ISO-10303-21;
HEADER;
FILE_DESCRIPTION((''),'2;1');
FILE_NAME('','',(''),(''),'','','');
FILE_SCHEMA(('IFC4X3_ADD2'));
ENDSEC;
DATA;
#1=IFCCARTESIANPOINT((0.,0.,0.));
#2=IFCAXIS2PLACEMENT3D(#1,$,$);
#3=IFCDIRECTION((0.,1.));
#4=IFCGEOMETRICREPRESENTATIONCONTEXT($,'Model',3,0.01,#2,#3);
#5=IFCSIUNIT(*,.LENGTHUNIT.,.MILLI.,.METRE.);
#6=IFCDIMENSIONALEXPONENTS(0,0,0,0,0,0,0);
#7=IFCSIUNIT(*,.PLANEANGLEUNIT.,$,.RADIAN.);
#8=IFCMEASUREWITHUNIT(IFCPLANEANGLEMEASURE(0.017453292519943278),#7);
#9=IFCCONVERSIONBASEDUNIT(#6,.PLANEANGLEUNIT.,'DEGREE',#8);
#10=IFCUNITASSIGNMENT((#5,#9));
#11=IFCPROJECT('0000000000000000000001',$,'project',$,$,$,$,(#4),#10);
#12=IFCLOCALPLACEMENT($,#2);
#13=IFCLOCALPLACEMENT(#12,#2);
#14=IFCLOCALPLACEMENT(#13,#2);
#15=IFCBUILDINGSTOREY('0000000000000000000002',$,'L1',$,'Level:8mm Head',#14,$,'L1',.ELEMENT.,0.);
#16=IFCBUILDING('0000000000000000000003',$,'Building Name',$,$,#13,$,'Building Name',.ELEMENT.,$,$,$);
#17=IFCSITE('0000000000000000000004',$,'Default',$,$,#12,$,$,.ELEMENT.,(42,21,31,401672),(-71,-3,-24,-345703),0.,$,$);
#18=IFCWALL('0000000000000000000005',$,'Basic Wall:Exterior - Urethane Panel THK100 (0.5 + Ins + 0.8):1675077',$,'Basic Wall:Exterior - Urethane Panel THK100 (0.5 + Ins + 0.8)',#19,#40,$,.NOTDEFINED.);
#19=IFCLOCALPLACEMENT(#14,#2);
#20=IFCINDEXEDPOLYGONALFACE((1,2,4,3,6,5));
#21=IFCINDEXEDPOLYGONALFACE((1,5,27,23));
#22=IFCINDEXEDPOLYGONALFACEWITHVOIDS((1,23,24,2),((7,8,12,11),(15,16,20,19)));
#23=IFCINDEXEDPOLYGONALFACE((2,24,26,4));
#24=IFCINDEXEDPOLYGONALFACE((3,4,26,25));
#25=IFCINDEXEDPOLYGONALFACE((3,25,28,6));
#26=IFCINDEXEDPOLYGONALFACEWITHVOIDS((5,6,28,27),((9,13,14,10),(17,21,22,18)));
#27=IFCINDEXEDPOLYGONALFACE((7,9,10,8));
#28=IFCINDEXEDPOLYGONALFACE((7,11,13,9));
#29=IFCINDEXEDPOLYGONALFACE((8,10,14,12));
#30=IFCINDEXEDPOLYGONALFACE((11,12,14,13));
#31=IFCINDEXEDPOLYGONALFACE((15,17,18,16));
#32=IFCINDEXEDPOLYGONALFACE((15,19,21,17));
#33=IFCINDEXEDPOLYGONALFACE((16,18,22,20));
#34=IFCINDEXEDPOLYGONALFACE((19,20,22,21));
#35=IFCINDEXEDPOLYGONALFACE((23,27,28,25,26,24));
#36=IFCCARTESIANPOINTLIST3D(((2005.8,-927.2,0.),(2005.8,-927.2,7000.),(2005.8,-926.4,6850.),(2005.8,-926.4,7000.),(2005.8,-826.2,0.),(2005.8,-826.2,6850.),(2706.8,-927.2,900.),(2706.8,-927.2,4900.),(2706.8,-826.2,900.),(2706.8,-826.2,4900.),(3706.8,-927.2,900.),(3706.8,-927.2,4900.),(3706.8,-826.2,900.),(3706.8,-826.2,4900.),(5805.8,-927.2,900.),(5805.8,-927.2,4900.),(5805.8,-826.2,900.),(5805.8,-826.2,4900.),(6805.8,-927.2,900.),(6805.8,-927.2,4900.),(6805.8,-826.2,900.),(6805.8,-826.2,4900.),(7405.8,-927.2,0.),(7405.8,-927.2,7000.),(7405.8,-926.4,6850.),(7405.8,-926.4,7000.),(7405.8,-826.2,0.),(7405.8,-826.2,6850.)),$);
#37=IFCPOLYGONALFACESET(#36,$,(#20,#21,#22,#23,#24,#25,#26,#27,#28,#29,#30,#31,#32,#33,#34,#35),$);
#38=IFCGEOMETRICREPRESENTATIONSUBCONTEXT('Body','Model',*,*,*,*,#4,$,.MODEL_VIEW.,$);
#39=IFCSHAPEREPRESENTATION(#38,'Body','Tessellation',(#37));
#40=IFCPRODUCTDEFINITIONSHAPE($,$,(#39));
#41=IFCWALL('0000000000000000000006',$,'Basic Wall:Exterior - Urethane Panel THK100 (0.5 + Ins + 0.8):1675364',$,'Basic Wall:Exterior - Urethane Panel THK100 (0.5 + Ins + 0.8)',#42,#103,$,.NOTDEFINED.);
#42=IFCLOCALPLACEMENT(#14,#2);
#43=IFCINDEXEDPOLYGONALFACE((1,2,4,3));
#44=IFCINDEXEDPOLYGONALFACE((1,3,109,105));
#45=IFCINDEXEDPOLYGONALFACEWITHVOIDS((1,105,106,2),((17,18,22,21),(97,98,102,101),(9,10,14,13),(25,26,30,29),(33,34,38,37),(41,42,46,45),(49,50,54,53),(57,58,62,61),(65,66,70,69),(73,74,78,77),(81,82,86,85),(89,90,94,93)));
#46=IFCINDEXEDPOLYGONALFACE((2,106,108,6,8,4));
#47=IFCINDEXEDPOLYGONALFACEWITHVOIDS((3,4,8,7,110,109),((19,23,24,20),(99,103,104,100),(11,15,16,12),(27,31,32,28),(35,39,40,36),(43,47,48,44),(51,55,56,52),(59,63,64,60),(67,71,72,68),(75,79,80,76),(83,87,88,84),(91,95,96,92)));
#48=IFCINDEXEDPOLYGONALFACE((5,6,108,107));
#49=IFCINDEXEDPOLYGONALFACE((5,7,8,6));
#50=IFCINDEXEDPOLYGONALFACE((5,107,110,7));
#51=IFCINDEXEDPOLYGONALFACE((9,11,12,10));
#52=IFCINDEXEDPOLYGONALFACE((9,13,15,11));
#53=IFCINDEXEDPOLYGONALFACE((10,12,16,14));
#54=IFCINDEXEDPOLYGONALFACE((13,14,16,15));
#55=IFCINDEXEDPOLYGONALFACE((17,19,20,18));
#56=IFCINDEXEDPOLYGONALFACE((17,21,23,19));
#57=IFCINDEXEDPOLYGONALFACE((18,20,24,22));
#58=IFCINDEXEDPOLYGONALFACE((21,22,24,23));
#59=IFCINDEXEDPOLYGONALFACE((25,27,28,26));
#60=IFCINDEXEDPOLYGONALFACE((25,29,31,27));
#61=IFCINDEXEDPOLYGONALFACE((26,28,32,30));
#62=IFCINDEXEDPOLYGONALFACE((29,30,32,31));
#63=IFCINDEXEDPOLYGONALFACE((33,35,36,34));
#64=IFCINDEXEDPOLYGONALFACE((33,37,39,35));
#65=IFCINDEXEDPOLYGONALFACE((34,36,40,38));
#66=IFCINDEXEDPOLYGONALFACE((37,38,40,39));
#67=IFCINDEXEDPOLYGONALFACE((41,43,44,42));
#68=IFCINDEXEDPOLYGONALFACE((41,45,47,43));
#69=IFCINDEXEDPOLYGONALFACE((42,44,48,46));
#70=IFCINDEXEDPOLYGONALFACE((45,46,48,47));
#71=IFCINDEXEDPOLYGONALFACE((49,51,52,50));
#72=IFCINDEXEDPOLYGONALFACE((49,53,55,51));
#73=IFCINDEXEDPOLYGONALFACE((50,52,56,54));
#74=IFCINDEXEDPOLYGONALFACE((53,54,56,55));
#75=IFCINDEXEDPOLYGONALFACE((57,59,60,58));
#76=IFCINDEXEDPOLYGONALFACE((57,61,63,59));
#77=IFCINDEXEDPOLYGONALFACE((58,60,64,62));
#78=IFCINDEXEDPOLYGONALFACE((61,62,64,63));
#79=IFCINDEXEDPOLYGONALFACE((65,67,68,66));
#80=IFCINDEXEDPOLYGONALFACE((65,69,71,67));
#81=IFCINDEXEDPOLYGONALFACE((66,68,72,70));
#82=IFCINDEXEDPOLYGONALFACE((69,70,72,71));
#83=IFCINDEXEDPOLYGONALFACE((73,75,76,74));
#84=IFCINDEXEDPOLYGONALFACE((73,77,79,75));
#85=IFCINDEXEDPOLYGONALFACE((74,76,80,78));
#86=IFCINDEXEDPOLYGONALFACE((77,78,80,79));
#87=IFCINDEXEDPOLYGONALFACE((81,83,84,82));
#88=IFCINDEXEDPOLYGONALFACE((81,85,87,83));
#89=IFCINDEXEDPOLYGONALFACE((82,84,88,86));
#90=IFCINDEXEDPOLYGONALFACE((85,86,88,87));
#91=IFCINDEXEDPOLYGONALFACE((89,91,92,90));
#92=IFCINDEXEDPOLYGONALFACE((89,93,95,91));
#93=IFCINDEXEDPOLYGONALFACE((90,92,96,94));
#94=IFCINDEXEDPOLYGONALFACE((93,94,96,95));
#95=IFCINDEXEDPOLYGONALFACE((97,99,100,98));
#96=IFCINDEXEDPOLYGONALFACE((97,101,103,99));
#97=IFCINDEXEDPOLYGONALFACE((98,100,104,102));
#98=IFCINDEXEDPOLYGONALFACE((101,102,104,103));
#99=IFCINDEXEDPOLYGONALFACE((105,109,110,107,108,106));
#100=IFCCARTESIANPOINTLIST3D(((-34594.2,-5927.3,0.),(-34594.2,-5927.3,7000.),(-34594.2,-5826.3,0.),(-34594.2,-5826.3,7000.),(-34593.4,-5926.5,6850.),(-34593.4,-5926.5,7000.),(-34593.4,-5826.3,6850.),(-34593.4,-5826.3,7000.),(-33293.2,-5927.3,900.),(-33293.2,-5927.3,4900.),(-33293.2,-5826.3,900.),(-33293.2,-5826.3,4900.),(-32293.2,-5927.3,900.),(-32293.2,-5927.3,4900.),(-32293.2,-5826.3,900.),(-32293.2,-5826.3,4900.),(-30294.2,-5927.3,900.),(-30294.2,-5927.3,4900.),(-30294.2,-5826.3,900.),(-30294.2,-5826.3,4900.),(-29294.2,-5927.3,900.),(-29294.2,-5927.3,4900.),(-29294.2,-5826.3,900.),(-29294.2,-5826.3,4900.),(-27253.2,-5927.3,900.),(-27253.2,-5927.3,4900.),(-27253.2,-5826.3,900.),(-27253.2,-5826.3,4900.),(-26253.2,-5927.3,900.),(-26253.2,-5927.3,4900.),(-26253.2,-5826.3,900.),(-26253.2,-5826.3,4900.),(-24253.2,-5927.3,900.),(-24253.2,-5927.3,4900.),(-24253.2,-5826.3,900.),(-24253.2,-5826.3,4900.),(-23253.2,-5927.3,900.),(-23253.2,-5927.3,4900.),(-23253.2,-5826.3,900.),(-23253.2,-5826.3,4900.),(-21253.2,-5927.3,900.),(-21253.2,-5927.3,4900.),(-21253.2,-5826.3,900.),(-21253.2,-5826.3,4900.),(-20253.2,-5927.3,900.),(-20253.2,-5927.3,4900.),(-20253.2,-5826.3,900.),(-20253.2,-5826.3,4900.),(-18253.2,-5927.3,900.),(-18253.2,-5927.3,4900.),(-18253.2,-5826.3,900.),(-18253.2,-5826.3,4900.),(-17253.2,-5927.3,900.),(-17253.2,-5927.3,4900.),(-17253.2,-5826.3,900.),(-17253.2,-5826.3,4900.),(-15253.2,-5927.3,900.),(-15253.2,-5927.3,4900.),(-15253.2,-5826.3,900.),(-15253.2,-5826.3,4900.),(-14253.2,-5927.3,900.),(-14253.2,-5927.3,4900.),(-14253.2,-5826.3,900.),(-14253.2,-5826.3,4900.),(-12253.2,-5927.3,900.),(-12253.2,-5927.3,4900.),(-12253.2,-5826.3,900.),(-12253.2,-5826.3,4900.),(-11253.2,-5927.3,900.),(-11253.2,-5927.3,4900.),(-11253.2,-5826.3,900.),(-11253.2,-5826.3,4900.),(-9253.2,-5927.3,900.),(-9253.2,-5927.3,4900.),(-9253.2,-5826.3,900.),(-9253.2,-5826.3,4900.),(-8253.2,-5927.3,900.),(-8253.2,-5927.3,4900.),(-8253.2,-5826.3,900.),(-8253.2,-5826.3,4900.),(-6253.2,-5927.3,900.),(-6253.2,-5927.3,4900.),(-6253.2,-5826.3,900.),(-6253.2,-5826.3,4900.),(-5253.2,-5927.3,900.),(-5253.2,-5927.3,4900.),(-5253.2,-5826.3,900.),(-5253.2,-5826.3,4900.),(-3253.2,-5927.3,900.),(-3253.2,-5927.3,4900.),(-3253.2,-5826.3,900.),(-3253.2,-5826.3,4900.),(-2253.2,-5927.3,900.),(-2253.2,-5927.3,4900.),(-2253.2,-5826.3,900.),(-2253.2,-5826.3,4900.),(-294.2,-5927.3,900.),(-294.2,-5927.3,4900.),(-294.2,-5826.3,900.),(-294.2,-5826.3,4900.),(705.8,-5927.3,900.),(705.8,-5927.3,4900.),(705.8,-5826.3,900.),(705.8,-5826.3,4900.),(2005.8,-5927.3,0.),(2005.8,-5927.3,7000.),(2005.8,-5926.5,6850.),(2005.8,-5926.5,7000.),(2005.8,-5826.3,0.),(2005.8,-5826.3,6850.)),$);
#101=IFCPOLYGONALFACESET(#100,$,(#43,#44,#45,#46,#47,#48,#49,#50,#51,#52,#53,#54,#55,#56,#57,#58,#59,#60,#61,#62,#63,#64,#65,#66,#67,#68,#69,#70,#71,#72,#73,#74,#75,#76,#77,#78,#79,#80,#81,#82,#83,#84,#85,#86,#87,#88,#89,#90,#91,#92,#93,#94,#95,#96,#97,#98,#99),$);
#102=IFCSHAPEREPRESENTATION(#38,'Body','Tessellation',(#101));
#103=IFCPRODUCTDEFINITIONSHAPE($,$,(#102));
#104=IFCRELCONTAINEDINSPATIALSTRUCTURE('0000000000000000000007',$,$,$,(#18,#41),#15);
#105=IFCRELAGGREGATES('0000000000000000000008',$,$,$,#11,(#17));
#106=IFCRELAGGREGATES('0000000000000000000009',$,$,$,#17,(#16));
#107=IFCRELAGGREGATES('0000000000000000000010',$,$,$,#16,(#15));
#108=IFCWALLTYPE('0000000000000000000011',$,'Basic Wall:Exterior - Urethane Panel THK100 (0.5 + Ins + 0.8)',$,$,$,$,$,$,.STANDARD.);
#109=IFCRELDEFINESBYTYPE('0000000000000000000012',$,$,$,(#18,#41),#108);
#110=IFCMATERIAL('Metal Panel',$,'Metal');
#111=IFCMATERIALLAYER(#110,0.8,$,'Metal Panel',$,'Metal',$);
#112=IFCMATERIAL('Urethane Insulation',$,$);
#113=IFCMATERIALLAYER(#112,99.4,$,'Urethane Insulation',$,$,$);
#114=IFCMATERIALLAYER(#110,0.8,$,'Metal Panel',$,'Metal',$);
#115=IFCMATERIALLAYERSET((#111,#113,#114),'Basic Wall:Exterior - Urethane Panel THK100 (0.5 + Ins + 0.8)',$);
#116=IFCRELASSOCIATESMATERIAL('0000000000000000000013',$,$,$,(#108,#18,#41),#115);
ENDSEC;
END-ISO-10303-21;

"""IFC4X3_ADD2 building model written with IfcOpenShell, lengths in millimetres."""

from ifc_helpers import new_model, entity, si_unit, converted_unit, direction, frame, frame_2d, origin, place, context, subcontext, project, spatial, polyline, rectangle, extrude, clip, bounded_halfspace, material, layer, layer_set, type_object, element, save


model = new_model("IFC4X3_ADD2")

# Units and contexts
model_context = context("Model", 3, precision=0.01, world=origin(), true_north=direction((0.0, 1.0)))
body_context = subcontext(model_context, "Body", "Model", "MODEL_VIEW")
ifc_project = project(units=[si_unit("LENGTHUNIT", "METRE", prefix="MILLI"), converted_unit("PLANEANGLEUNIT", "DEGREE", entity("IfcPlaneAngleMeasure", 0.017453292519943278), si_unit("PLANEANGLEUNIT", "RADIAN"), dimensions=[0, 0, 0, 0, 0, 0, 0])], contexts=[model_context])

# Site, building, storey
site_placement = place(None, origin())
site = spatial("IfcSite", under=ifc_project, at=site_placement, Name="Default", CompositionType="ELEMENT", RefLatitude=(42, 21, 31, 401672), RefLongitude=(-71, -3, -24, -345703), RefElevation=0.0)
building_placement = place(site_placement, origin())
building = spatial("IfcBuilding", under=site, at=building_placement, Name="Building Name", LongName="Building Name", CompositionType="ELEMENT")
storey_placement = place(building_placement, origin())
storey = spatial("IfcBuildingStorey", under=building, at=storey_placement, Name="L1", ObjectType="Level:8mm Head", LongName="L1", CompositionType="ELEMENT", Elevation=0.0)

# Wall, openings
ifc_material_1 = material(Name="Metal Panel", Category="Metal")
ifc_layer_1 = layer(ifc_material_1, 0.8, Name="Metal Panel", Category="Metal")
ifc_material_2 = material(Name="Urethane Insulation")
ifc_layer_2 = layer(ifc_material_2, 99.4, Name="Urethane Insulation")
ifc_layer_3 = layer(ifc_material_1, 0.8, Name="Metal Panel", Category="Metal")
ifc_layer_set = layer_set([ifc_layer_1, ifc_layer_2, ifc_layer_3], Name="Basic Wall:Exterior - Urethane Panel THK100 (0.5 + Ins + 0.8)")
wall_type = type_object("IfcWallType", Name="Basic Wall:Exterior - Urethane Panel THK100 (0.5 + Ins + 0.8)", PredefinedType="STANDARD", material=ifc_layer_set)
wall_1_placement = place(storey_placement, frame((2005.8, -876.7, 0.0)))
wall_1 = element("IfcWall", 1, at=wall_1_placement, inside=storey, type_object=wall_type, material=ifc_layer_set, Name="Basic Wall:Exterior - Urethane Panel THK100 (0.5 + Ins + 0.8):1675077", ObjectType="Basic Wall:Exterior - Urethane Panel THK100 (0.5 + Ins + 0.8)", PredefinedType="NOTDEFINED", context=body_context, shape_type="Clipping", body=[
    clip(extrude(rectangle(XDim=5400.0, YDim=101.0, at=frame_2d((2700.0, 0.0), x_axis=(-1.0, 0.0))), origin(), (0.0, 0.0, 1.0), 7000.0), bounded_halfspace(frame((5400.0, -49.7, 6850.0), z_axis=(0.0, 0.0, -1.0), x_axis=(1.0, 0.0, 0.0)), True, frame((5400.0, -49.7, 6850.0)), polyline([(0.0, 0.0), (0.0, 100.2), (-5400.0, 100.2), (-5400.0, 0.0), (-5299.8, 0.0), (0.0, 0.0)]))),
])
opening_1_placement = place(wall_1_placement, frame((1701.0, 50.5, 900.0)))
element("IfcOpeningElement", 2, at=opening_1_placement, cuts=wall_1, PredefinedType="OPENING", context=body_context, shape_type="SweptSolid", body=[
    extrude(rectangle(XDim=4000.0, YDim=1000.0, at=frame_2d((2000.0, 500.0), x_axis=(-1.0, 0.0))), frame((0.0, 0.0, 0.0), z_axis=(0.0, -1.0, 0.0), x_axis=(0.0, 0.0, 1.0)), (0.0, 0.0, 1.0), 101.0),
])
opening_2_placement = place(wall_1_placement, frame((4800.0, 50.5, 900.0)))
element("IfcOpeningElement", 3, at=opening_2_placement, cuts=wall_1, PredefinedType="OPENING", context=body_context, shape_type="SweptSolid", body=[
    extrude(rectangle(XDim=4000.0, YDim=1000.0, at=frame_2d((2000.0, 500.0), x_axis=(-1.0, 0.0))), frame((0.0, 0.0, 0.0), z_axis=(0.0, -1.0, 0.0), x_axis=(0.0, 0.0, 1.0)), (0.0, 0.0, 1.0), 101.0),
])

# Wall, openings
wall_2_placement = place(storey_placement, frame((2005.8, -5876.8, 0.0), z_axis=(0.0, 0.0, 1.0), x_axis=(-1.0, 0.0, 0.0)))
wall_2 = element("IfcWall", 4, at=wall_2_placement, inside=storey, type_object=wall_type, material=ifc_layer_set, Name="Basic Wall:Exterior - Urethane Panel THK100 (0.5 + Ins + 0.8):1675364", ObjectType="Basic Wall:Exterior - Urethane Panel THK100 (0.5 + Ins + 0.8)", PredefinedType="NOTDEFINED", context=body_context, shape_type="Clipping", body=[
    clip(extrude(rectangle(XDim=36600.0, YDim=101.0, at=frame_2d((18300.0, 0.0), x_axis=(-1.0, 0.0))), origin(), (0.0, 0.0, 1.0), 7000.0), bounded_halfspace(frame((0.0, -50.5, 6850.0), z_axis=(0.0, 0.0, -1.0), x_axis=(-1.0, 0.0, 0.0)), True, frame((0.0, -50.5, 6850.0)), polyline([(0.0, 0.0), (29899.0, 0.0), (30000.0, 0.0), (36499.0, 0.0), (36599.2, 0.0), (36599.2, 100.2), (0.0, 100.2), (0.0, 0.0)]))),
])
opening_3_placement = place(wall_2_placement, frame((34299.0, -50.5, 900.0)))
element("IfcOpeningElement", 5, at=opening_3_placement, cuts=wall_2, PredefinedType="OPENING", context=body_context, shape_type="SweptSolid", body=[
    extrude(rectangle(XDim=4000.0, YDim=1000.0, at=frame_2d((2000.0, 500.0), x_axis=(-1.0, 0.0))), frame((0.0, 0.0, 0.0), z_axis=(0.0, 1.0, 0.0), x_axis=(0.0, 0.0, 1.0)), (0.0, 0.0, 1.0), 101.0),
])
opening_4_placement = place(wall_2_placement, frame((31300.0, -50.5, 900.0)))
element("IfcOpeningElement", 6, at=opening_4_placement, cuts=wall_2, PredefinedType="OPENING", context=body_context, shape_type="SweptSolid", body=[
    extrude(rectangle(XDim=4000.0, YDim=1000.0, at=frame_2d((2000.0, 500.0), x_axis=(-1.0, 0.0))), frame((0.0, 0.0, 0.0), z_axis=(0.0, 1.0, 0.0), x_axis=(0.0, 0.0, 1.0)), (0.0, 0.0, 1.0), 101.0),
])
opening_5_placement = place(wall_2_placement, frame((28259.0, -50.5, 900.0)))
element("IfcOpeningElement", 7, at=opening_5_placement, cuts=wall_2, PredefinedType="OPENING", context=body_context, shape_type="SweptSolid", body=[
    extrude(rectangle(XDim=4000.0, YDim=1000.0, at=frame_2d((2000.0, 500.0), x_axis=(-1.0, 0.0))), frame((0.0, 0.0, 0.0), z_axis=(0.0, 1.0, 0.0), x_axis=(0.0, 0.0, 1.0)), (0.0, 0.0, 1.0), 101.0),
])
opening_6_placement = place(wall_2_placement, frame((25259.0, -50.5, 900.0)))
element("IfcOpeningElement", 8, at=opening_6_placement, cuts=wall_2, PredefinedType="OPENING", context=body_context, shape_type="SweptSolid", body=[
    extrude(rectangle(XDim=4000.0, YDim=1000.0, at=frame_2d((2000.0, 500.0), x_axis=(-1.0, 0.0))), frame((0.0, 0.0, 0.0), z_axis=(0.0, 1.0, 0.0), x_axis=(0.0, 0.0, 1.0)), (0.0, 0.0, 1.0), 101.0),
])
opening_7_placement = place(wall_2_placement, frame((22259.0, -50.5, 900.0)))
element("IfcOpeningElement", 9, at=opening_7_placement, cuts=wall_2, PredefinedType="OPENING", context=body_context, shape_type="SweptSolid", body=[
    extrude(rectangle(XDim=4000.0, YDim=1000.0, at=frame_2d((2000.0, 500.0), x_axis=(-1.0, 0.0))), frame((0.0, 0.0, 0.0), z_axis=(0.0, 1.0, 0.0), x_axis=(0.0, 0.0, 1.0)), (0.0, 0.0, 1.0), 101.0),
])
opening_8_placement = place(wall_2_placement, frame((19259.0, -50.5, 900.0)))
element("IfcOpeningElement", 10, at=opening_8_placement, cuts=wall_2, PredefinedType="OPENING", context=body_context, shape_type="SweptSolid", body=[
    extrude(rectangle(XDim=4000.0, YDim=1000.0, at=frame_2d((2000.0, 500.0), x_axis=(-1.0, 0.0))), frame((0.0, 0.0, 0.0), z_axis=(0.0, 1.0, 0.0), x_axis=(0.0, 0.0, 1.0)), (0.0, 0.0, 1.0), 101.0),
])
opening_9_placement = place(wall_2_placement, frame((16259.0, -50.5, 900.0)))
element("IfcOpeningElement", 11, at=opening_9_placement, cuts=wall_2, PredefinedType="OPENING", context=body_context, shape_type="SweptSolid", body=[
    extrude(rectangle(XDim=4000.0, YDim=1000.0, at=frame_2d((2000.0, 500.0), x_axis=(-1.0, 0.0))), frame((0.0, 0.0, 0.0), z_axis=(0.0, 1.0, 0.0), x_axis=(0.0, 0.0, 1.0)), (0.0, 0.0, 1.0), 101.0),
])
opening_10_placement = place(wall_2_placement, frame((13259.0, -50.5, 900.0)))
element("IfcOpeningElement", 12, at=opening_10_placement, cuts=wall_2, PredefinedType="OPENING", context=body_context, shape_type="SweptSolid", body=[
    extrude(rectangle(XDim=4000.0, YDim=1000.0, at=frame_2d((2000.0, 500.0), x_axis=(-1.0, 0.0))), frame((0.0, 0.0, 0.0), z_axis=(0.0, 1.0, 0.0), x_axis=(0.0, 0.0, 1.0)), (0.0, 0.0, 1.0), 101.0),
])
opening_11_placement = place(wall_2_placement, frame((10259.0, -50.5, 900.0)))
element("IfcOpeningElement", 13, at=opening_11_placement, cuts=wall_2, PredefinedType="OPENING", context=body_context, shape_type="SweptSolid", body=[
    extrude(rectangle(XDim=4000.0, YDim=1000.0, at=frame_2d((2000.0, 500.0), x_axis=(-1.0, 0.0))), frame((0.0, 0.0, 0.0), z_axis=(0.0, 1.0, 0.0), x_axis=(0.0, 0.0, 1.0)), (0.0, 0.0, 1.0), 101.0),
])
opening_12_placement = place(wall_2_placement, frame((7259.0, -50.5, 900.0)))
element("IfcOpeningElement", 14, at=opening_12_placement, cuts=wall_2, PredefinedType="OPENING", context=body_context, shape_type="SweptSolid", body=[
    extrude(rectangle(XDim=4000.0, YDim=1000.0, at=frame_2d((2000.0, 500.0), x_axis=(-1.0, 0.0))), frame((0.0, 0.0, 0.0), z_axis=(0.0, 1.0, 0.0), x_axis=(0.0, 0.0, 1.0)), (0.0, 0.0, 1.0), 101.0),
])
opening_13_placement = place(wall_2_placement, frame((4259.0, -50.5, 900.0)))
element("IfcOpeningElement", 15, at=opening_13_placement, cuts=wall_2, PredefinedType="OPENING", context=body_context, shape_type="SweptSolid", body=[
    extrude(rectangle(XDim=4000.0, YDim=1000.0, at=frame_2d((2000.0, 500.0), x_axis=(-1.0, 0.0))), frame((0.0, 0.0, 0.0), z_axis=(0.0, 1.0, 0.0), x_axis=(0.0, 0.0, 1.0)), (0.0, 0.0, 1.0), 101.0),
])
opening_14_placement = place(wall_2_placement, frame((1300.0, -50.5, 900.0)))
element("IfcOpeningElement", 16, at=opening_14_placement, cuts=wall_2, PredefinedType="OPENING", context=body_context, shape_type="SweptSolid", body=[
    extrude(rectangle(XDim=4000.0, YDim=1000.0, at=frame_2d((2000.0, 500.0), x_axis=(-1.0, 0.0))), frame((0.0, 0.0, 0.0), z_axis=(0.0, 1.0, 0.0), x_axis=(0.0, 0.0, 1.0)), (0.0, 0.0, 1.0), 101.0),
])

save(model, "model.ifc")
